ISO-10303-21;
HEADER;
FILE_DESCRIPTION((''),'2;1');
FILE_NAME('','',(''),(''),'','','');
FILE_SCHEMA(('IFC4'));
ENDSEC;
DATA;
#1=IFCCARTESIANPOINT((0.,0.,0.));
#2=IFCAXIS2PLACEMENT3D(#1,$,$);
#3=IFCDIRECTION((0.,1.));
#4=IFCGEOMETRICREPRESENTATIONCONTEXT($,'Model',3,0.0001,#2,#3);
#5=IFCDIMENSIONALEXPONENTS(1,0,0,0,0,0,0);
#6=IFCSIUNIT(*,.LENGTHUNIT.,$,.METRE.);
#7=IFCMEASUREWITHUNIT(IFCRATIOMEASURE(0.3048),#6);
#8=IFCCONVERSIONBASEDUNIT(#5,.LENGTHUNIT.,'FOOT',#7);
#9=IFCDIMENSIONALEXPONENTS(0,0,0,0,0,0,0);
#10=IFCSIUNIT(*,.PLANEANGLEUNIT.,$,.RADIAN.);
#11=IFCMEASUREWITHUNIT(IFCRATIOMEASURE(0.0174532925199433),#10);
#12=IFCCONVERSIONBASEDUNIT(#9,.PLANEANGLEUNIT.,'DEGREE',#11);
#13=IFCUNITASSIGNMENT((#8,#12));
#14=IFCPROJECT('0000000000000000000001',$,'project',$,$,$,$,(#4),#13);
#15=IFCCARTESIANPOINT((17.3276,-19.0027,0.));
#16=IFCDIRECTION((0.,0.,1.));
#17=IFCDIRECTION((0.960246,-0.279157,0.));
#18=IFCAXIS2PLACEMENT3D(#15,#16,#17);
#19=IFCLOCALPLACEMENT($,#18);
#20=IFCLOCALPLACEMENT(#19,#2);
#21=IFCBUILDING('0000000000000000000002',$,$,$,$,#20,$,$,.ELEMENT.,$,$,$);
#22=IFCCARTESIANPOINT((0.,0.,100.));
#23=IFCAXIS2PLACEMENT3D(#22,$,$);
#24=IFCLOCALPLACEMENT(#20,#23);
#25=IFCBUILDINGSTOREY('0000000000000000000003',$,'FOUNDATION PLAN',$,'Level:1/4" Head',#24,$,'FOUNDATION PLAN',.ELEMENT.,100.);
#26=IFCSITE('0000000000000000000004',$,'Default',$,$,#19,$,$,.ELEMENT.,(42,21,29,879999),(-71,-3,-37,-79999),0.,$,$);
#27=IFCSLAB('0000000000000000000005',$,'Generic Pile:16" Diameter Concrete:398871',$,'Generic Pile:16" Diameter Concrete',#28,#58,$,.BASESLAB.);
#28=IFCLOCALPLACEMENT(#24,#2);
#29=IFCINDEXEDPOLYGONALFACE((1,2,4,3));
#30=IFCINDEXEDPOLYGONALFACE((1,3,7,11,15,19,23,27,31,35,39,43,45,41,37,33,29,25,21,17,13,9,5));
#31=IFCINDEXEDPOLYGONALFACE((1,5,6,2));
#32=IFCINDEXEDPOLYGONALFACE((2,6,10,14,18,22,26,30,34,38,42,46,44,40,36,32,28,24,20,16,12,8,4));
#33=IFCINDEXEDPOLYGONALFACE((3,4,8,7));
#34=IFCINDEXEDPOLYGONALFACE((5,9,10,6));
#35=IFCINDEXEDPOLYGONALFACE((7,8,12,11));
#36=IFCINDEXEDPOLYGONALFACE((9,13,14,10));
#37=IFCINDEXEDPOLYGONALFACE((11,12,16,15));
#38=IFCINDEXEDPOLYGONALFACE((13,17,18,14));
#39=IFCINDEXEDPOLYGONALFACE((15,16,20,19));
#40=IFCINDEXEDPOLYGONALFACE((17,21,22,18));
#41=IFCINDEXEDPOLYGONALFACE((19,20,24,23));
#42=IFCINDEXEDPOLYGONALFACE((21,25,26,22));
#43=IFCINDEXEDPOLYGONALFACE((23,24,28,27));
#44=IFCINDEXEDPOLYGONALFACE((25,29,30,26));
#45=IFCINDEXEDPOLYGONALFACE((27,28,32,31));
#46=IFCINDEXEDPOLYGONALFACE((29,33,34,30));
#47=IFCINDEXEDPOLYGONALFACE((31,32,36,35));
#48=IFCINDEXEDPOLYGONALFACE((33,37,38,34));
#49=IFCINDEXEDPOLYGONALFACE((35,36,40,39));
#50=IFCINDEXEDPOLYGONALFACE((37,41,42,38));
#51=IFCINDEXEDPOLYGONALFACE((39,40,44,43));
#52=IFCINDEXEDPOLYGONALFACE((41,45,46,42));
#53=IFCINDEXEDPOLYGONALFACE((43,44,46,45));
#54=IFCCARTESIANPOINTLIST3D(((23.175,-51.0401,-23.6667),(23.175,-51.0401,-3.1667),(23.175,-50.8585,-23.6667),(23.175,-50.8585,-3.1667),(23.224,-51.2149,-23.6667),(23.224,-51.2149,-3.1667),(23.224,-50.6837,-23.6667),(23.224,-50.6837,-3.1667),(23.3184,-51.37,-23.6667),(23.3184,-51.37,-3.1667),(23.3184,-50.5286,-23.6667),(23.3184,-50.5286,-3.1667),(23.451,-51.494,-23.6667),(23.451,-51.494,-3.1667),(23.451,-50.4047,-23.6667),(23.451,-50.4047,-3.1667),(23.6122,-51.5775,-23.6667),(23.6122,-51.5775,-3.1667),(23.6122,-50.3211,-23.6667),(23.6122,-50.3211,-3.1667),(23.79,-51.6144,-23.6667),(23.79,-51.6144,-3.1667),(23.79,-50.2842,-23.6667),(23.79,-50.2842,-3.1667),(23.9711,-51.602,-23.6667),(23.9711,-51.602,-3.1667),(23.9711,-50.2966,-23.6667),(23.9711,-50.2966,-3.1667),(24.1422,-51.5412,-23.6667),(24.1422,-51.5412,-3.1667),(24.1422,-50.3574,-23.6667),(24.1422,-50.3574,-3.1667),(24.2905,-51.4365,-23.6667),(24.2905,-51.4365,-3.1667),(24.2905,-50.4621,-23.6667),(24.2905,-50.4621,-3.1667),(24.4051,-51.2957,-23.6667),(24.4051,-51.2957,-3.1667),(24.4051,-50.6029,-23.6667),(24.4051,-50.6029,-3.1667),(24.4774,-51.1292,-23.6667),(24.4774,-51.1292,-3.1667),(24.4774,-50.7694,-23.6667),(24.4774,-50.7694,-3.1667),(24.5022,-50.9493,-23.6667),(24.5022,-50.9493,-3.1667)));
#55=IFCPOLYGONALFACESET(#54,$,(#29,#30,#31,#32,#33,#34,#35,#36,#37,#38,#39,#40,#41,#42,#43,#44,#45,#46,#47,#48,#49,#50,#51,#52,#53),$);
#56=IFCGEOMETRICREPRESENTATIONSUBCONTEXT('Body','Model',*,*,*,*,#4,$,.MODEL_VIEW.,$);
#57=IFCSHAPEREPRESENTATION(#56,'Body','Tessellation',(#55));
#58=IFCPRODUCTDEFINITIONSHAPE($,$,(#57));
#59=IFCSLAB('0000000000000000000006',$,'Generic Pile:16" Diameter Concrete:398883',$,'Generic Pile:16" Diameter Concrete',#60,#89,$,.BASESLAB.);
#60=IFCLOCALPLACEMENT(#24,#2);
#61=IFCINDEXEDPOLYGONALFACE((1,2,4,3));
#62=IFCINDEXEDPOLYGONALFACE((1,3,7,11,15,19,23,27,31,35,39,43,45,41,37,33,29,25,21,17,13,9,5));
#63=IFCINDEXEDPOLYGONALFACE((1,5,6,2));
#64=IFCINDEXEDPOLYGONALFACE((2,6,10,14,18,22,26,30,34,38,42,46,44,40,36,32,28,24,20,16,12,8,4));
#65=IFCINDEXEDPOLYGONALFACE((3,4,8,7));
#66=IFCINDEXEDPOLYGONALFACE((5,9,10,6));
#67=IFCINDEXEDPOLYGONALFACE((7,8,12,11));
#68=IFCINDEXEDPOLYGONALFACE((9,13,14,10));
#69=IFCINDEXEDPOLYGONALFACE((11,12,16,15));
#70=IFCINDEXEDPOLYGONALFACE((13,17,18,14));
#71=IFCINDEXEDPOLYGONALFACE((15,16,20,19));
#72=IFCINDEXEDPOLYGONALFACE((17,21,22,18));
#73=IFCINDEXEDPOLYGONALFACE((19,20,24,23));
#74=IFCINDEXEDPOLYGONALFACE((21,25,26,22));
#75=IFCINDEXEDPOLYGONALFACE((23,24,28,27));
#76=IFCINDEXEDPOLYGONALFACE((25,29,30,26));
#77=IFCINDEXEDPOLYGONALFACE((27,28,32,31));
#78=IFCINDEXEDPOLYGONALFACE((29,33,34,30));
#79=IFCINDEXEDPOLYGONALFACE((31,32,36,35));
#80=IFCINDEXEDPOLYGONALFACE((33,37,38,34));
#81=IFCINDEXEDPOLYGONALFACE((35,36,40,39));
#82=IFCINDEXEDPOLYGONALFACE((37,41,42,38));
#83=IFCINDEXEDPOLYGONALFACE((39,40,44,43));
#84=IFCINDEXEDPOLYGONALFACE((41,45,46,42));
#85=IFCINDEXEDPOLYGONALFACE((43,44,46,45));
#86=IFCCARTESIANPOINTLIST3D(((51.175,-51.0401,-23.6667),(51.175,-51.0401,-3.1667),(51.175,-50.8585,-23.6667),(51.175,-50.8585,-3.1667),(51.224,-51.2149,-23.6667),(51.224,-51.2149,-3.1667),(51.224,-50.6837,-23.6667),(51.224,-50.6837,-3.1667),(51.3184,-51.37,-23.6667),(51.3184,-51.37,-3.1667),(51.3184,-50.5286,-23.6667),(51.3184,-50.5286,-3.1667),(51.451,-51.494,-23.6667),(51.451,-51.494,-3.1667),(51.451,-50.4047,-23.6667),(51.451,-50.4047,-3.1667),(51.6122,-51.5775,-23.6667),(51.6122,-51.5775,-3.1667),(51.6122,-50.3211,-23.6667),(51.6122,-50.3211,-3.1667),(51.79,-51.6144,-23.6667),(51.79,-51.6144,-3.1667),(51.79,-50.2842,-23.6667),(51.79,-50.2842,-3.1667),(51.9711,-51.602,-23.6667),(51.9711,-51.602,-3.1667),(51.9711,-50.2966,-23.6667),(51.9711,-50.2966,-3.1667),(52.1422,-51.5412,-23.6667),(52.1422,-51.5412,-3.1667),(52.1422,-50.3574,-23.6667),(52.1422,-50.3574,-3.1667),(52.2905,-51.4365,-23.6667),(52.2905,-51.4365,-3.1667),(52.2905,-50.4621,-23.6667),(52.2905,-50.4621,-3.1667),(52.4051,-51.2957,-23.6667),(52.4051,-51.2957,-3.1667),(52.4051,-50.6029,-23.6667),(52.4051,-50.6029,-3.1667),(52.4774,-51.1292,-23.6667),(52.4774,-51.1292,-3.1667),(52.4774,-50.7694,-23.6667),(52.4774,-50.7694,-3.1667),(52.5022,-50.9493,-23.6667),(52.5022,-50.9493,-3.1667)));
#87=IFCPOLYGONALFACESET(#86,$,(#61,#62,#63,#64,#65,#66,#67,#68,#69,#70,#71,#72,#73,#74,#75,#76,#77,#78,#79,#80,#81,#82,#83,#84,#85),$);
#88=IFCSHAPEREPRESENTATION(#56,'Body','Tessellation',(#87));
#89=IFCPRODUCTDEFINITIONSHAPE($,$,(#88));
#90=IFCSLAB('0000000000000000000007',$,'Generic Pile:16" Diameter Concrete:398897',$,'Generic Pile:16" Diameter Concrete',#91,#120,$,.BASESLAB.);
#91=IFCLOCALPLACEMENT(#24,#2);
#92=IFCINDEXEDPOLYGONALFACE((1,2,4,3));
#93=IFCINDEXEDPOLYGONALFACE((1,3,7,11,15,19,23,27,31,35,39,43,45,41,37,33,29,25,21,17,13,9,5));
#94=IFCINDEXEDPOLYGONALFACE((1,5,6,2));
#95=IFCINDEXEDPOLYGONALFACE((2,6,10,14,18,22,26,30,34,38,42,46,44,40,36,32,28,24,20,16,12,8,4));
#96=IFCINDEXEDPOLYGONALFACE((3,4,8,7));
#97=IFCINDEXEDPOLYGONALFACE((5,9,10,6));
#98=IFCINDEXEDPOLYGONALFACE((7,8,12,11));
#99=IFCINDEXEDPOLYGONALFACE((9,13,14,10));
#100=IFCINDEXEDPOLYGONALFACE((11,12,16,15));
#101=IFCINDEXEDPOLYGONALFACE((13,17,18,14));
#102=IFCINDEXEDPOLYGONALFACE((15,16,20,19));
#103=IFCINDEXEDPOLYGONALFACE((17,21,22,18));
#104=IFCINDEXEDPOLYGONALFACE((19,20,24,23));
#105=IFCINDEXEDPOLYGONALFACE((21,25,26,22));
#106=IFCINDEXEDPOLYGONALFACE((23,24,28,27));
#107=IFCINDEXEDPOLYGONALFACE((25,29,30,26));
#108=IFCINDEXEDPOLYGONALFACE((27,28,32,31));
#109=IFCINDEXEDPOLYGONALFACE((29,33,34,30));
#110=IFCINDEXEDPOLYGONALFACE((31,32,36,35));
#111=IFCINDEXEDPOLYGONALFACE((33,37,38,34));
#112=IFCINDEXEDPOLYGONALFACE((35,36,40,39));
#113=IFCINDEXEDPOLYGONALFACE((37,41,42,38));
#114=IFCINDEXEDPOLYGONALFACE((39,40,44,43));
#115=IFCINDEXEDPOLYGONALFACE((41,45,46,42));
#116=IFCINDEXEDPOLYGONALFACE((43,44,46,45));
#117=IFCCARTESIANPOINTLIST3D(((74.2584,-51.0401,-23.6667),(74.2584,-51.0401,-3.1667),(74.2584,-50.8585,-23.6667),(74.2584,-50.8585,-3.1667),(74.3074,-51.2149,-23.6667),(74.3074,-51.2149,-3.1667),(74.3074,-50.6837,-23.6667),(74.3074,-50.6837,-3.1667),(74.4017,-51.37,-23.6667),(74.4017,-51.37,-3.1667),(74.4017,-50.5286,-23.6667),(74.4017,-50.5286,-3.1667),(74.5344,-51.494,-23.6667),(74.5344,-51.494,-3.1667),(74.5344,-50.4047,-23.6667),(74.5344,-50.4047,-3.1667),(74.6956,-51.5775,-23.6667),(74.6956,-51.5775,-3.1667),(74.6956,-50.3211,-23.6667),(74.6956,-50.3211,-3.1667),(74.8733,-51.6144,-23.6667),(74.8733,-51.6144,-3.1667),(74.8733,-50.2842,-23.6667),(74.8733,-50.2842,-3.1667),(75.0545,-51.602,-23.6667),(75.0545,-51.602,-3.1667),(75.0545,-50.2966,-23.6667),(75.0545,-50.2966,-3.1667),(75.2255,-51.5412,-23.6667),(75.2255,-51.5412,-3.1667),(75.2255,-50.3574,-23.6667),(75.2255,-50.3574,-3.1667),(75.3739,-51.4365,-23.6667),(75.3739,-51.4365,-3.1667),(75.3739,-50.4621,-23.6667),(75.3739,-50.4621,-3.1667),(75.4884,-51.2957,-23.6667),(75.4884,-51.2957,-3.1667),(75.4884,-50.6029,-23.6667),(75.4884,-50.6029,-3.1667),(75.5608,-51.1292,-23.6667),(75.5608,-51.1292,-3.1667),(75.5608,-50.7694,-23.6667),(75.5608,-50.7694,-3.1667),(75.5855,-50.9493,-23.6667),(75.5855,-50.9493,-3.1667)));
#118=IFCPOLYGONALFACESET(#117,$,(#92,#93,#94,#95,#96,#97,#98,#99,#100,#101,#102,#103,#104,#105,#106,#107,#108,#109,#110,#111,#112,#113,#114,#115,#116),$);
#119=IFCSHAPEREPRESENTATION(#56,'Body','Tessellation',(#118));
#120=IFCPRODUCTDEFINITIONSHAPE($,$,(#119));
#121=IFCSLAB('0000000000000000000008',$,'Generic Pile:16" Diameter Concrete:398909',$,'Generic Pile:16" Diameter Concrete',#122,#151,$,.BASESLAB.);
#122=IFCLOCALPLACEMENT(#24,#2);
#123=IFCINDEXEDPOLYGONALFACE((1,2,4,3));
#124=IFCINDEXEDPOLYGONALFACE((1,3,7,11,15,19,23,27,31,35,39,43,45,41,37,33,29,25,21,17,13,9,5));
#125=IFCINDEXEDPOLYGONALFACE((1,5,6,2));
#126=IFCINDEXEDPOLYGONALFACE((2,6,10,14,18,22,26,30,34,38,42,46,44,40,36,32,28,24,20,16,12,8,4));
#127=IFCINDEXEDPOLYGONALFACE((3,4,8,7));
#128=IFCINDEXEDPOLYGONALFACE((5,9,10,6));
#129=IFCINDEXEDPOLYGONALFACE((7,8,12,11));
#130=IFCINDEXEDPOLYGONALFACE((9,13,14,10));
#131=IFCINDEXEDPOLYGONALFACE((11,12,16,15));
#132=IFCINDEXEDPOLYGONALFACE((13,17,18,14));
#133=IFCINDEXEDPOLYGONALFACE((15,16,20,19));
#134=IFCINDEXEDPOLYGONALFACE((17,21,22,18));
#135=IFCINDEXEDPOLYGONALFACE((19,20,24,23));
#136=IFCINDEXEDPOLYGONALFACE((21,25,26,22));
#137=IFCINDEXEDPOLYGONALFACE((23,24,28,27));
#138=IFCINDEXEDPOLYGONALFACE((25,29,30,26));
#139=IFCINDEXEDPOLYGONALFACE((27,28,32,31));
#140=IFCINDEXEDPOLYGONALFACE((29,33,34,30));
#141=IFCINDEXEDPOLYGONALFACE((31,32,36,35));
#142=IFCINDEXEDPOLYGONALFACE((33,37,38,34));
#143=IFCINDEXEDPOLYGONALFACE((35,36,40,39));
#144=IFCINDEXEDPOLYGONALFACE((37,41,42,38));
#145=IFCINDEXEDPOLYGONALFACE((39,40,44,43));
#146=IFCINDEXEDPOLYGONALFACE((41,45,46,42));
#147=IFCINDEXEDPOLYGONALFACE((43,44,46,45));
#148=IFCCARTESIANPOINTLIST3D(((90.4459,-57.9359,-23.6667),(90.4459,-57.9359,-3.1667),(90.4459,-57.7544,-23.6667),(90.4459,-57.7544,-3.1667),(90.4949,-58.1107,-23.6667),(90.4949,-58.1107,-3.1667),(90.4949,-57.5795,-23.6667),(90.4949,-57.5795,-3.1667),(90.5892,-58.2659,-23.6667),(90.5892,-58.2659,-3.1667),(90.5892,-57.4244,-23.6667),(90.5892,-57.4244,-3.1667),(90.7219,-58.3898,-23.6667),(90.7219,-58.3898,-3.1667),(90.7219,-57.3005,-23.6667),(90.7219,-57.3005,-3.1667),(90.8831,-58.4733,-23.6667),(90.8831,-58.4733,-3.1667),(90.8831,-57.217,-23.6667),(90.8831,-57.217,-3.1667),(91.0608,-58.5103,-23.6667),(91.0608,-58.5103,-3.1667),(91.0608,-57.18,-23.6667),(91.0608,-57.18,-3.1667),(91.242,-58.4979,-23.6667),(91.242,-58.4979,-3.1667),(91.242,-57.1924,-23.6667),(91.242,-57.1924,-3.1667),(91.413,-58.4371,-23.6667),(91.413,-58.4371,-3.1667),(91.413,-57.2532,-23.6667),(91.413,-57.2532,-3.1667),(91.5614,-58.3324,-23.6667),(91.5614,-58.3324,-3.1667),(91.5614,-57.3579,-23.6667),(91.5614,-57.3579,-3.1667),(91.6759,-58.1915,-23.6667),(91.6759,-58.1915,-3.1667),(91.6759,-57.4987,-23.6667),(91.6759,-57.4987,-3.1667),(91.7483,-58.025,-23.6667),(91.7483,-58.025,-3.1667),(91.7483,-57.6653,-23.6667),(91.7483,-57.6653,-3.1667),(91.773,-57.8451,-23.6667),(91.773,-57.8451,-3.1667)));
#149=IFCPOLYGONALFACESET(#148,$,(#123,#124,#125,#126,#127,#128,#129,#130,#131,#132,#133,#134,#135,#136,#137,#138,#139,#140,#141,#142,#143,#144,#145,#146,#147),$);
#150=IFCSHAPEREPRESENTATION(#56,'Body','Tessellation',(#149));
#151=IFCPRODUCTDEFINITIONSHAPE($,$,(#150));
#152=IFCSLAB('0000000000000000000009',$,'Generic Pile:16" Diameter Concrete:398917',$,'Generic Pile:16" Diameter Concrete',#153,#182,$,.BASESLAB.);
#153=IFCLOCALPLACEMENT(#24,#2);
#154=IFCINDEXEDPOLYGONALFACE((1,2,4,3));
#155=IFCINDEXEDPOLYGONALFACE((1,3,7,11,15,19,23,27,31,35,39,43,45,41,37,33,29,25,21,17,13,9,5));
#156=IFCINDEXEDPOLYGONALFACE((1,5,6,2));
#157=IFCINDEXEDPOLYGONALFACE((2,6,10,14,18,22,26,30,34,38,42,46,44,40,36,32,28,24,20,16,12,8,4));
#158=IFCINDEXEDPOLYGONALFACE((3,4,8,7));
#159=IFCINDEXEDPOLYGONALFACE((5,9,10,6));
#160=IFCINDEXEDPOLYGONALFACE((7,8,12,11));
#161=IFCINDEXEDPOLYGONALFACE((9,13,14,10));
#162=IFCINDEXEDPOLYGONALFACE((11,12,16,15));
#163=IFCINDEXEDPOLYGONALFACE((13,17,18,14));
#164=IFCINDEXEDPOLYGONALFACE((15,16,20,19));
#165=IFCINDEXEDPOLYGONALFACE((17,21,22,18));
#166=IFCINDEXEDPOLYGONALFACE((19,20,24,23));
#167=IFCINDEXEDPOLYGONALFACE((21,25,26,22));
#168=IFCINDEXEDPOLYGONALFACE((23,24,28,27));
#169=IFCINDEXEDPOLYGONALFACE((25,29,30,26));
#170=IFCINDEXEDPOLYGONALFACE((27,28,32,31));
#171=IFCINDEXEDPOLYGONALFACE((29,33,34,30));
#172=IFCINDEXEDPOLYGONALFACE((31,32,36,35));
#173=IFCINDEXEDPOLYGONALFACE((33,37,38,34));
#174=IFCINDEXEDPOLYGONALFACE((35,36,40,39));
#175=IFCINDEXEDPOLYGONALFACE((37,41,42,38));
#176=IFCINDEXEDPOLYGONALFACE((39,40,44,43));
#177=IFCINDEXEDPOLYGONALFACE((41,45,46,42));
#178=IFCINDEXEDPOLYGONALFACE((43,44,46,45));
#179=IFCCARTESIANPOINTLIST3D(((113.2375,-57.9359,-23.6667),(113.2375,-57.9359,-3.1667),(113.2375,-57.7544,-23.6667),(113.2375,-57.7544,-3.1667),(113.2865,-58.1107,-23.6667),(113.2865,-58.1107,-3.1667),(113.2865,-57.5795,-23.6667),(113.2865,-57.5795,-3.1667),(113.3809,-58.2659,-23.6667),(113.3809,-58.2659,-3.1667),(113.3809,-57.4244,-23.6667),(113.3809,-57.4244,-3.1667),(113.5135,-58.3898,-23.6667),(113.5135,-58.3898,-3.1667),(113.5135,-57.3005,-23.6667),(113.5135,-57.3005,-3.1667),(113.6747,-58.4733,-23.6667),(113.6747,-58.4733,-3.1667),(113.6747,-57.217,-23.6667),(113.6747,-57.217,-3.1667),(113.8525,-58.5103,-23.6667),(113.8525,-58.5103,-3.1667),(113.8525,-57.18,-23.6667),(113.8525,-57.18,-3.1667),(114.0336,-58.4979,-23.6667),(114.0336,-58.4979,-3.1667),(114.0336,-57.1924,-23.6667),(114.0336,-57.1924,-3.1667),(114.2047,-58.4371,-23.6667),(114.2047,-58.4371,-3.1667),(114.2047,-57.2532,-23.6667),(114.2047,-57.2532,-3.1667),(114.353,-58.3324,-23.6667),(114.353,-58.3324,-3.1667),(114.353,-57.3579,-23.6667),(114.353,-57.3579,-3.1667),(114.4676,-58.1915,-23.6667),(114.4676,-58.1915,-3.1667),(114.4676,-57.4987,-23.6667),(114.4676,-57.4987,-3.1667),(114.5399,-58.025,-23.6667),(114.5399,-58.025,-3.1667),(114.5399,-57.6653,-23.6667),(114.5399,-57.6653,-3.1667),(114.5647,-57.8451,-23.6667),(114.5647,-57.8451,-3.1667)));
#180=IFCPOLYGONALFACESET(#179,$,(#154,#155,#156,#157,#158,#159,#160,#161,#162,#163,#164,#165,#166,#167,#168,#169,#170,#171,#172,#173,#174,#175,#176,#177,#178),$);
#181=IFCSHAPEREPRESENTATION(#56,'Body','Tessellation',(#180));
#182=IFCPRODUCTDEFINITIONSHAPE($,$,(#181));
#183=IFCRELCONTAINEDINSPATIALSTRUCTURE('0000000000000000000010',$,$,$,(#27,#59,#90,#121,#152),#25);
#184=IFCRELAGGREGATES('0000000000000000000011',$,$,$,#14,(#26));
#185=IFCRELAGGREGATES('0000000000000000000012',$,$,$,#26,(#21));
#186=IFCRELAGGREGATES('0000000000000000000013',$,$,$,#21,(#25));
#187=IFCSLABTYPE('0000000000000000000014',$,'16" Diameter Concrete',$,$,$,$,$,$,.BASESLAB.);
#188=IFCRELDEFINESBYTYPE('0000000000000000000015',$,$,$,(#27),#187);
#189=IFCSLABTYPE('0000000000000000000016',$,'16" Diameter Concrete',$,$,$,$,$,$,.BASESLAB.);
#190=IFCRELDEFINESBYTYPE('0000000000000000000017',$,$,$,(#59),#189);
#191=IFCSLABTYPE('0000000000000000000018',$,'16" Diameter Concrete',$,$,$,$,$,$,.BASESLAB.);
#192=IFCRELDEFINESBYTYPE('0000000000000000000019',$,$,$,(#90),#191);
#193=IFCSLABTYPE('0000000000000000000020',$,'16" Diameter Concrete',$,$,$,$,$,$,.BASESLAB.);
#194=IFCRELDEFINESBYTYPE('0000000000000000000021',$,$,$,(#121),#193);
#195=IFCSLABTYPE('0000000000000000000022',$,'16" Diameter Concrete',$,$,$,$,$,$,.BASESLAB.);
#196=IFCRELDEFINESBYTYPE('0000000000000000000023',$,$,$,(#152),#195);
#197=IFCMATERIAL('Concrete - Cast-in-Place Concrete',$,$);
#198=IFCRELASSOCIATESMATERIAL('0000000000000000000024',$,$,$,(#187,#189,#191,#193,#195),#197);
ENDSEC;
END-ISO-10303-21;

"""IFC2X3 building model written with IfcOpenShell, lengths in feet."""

from ifc_helpers import new_model, entity, si_unit, converted_unit, direction, frame, origin, origin_2d_with_axis, place, context, subcontext, project, spatial, circle, extrude, material, type_object, element, save


model = new_model("IFC2X3")

# Units and contexts
model_context = context("Model", 3, precision=0.0001, world=origin(), true_north=direction((0.0, 1.0)))
body_context = subcontext(model_context, "Body", "Model", "MODEL_VIEW")
ifc_project = project(units=[converted_unit("LENGTHUNIT", "FOOT", entity("IfcRatioMeasure", 0.3048), si_unit("LENGTHUNIT", "METRE"), dimensions=[1, 0, 0, 0, 0, 0, 0]), converted_unit("PLANEANGLEUNIT", "DEGREE", entity("IfcRatioMeasure", 0.0174532925199433), si_unit("PLANEANGLEUNIT", "RADIAN"), dimensions=[0, 0, 0, 0, 0, 0, 0])], contexts=[model_context])

# Site, building, storey
site_placement = place(None, frame((17.3276, -19.0027, 0.0), z_axis=(0.0, 0.0, 1.0), x_axis=(0.960246, -0.279157, 0.0)))
site = spatial("IfcSite", under=ifc_project, at=site_placement, Name="Default", CompositionType="ELEMENT", RefLatitude=(42, 21, 29, 879999), RefLongitude=(-71, -3, -37, -79999), RefElevation=0.0)
building_placement = place(site_placement, origin())
building = spatial("IfcBuilding", under=site, at=building_placement, CompositionType="ELEMENT")
storey_placement = place(building_placement, frame((0.0, 0.0, 100.0)))
storey = spatial("IfcBuildingStorey", under=building, at=storey_placement, Name="FOUNDATION PLAN", ObjectType="Level:1/4\" Head", LongName="FOUNDATION PLAN", CompositionType="ELEMENT", Elevation=100.0)

# Slabs
ifc_material_1 = material(Name="Concrete - Cast-in-Place Concrete")
slab_type_1 = type_object("IfcSlabType", Name="16\" Diameter Concrete", PredefinedType="BASESLAB", material=ifc_material_1)
slab_1_placement = place(storey_placement, origin())
element("IfcSlab", 1, at=slab_1_placement, inside=storey, type_object=slab_type_1, Name="Generic Pile:16\" Diameter Concrete:398871", ObjectType="Generic Pile:16\" Diameter Concrete", PredefinedType="BASESLAB", context=body_context, shape_type="SweptSolid", body=[
    extrude(circle(Radius=0.6667, at=origin_2d_with_axis()), frame((23.8355, -50.9493, -23.6667)), (0.0, 0.0, 1.0), 20.5),
])
slab_type_2 = type_object("IfcSlabType", Name="16\" Diameter Concrete", PredefinedType="BASESLAB", material=ifc_material_1)
slab_2_placement = place(storey_placement, origin())
element("IfcSlab", 2, at=slab_2_placement, inside=storey, type_object=slab_type_2, Name="Generic Pile:16\" Diameter Concrete:398883", ObjectType="Generic Pile:16\" Diameter Concrete", PredefinedType="BASESLAB", context=body_context, shape_type="SweptSolid", body=[
    extrude(circle(Radius=0.6667, at=origin_2d_with_axis()), frame((51.8355, -50.9493, -23.6667)), (0.0, 0.0, 1.0), 20.5),
])
slab_type_3 = type_object("IfcSlabType", Name="16\" Diameter Concrete", PredefinedType="BASESLAB", material=ifc_material_1)
slab_3_placement = place(storey_placement, origin())
element("IfcSlab", 3, at=slab_3_placement, inside=storey, type_object=slab_type_3, Name="Generic Pile:16\" Diameter Concrete:398897", ObjectType="Generic Pile:16\" Diameter Concrete", PredefinedType="BASESLAB", context=body_context, shape_type="SweptSolid", body=[
    extrude(circle(Radius=0.6667, at=origin_2d_with_axis()), frame((74.9188, -50.9493, -23.6667)), (0.0, 0.0, 1.0), 20.5),
])
slab_type_4 = type_object("IfcSlabType", Name="16\" Diameter Concrete", PredefinedType="BASESLAB", material=ifc_material_1)
slab_4_placement = place(storey_placement, origin())
element("IfcSlab", 4, at=slab_4_placement, inside=storey, type_object=slab_type_4, Name="Generic Pile:16\" Diameter Concrete:398909", ObjectType="Generic Pile:16\" Diameter Concrete", PredefinedType="BASESLAB", context=body_context, shape_type="SweptSolid", body=[
    extrude(circle(Radius=0.6667, at=origin_2d_with_axis()), frame((91.1063, -57.8451, -23.6667)), (0.0, 0.0, 1.0), 20.5),
])
slab_type_5 = type_object("IfcSlabType", Name="16\" Diameter Concrete", PredefinedType="BASESLAB", material=ifc_material_1)
slab_5_placement = place(storey_placement, origin())
element("IfcSlab", 5, at=slab_5_placement, inside=storey, type_object=slab_type_5, Name="Generic Pile:16\" Diameter Concrete:398917", ObjectType="Generic Pile:16\" Diameter Concrete", PredefinedType="BASESLAB", context=body_context, shape_type="SweptSolid", body=[
    extrude(circle(Radius=0.6667, at=origin_2d_with_axis()), frame((113.898, -57.8451, -23.6667)), (0.0, 0.0, 1.0), 20.5),
])

save(model, "model.ifc")
